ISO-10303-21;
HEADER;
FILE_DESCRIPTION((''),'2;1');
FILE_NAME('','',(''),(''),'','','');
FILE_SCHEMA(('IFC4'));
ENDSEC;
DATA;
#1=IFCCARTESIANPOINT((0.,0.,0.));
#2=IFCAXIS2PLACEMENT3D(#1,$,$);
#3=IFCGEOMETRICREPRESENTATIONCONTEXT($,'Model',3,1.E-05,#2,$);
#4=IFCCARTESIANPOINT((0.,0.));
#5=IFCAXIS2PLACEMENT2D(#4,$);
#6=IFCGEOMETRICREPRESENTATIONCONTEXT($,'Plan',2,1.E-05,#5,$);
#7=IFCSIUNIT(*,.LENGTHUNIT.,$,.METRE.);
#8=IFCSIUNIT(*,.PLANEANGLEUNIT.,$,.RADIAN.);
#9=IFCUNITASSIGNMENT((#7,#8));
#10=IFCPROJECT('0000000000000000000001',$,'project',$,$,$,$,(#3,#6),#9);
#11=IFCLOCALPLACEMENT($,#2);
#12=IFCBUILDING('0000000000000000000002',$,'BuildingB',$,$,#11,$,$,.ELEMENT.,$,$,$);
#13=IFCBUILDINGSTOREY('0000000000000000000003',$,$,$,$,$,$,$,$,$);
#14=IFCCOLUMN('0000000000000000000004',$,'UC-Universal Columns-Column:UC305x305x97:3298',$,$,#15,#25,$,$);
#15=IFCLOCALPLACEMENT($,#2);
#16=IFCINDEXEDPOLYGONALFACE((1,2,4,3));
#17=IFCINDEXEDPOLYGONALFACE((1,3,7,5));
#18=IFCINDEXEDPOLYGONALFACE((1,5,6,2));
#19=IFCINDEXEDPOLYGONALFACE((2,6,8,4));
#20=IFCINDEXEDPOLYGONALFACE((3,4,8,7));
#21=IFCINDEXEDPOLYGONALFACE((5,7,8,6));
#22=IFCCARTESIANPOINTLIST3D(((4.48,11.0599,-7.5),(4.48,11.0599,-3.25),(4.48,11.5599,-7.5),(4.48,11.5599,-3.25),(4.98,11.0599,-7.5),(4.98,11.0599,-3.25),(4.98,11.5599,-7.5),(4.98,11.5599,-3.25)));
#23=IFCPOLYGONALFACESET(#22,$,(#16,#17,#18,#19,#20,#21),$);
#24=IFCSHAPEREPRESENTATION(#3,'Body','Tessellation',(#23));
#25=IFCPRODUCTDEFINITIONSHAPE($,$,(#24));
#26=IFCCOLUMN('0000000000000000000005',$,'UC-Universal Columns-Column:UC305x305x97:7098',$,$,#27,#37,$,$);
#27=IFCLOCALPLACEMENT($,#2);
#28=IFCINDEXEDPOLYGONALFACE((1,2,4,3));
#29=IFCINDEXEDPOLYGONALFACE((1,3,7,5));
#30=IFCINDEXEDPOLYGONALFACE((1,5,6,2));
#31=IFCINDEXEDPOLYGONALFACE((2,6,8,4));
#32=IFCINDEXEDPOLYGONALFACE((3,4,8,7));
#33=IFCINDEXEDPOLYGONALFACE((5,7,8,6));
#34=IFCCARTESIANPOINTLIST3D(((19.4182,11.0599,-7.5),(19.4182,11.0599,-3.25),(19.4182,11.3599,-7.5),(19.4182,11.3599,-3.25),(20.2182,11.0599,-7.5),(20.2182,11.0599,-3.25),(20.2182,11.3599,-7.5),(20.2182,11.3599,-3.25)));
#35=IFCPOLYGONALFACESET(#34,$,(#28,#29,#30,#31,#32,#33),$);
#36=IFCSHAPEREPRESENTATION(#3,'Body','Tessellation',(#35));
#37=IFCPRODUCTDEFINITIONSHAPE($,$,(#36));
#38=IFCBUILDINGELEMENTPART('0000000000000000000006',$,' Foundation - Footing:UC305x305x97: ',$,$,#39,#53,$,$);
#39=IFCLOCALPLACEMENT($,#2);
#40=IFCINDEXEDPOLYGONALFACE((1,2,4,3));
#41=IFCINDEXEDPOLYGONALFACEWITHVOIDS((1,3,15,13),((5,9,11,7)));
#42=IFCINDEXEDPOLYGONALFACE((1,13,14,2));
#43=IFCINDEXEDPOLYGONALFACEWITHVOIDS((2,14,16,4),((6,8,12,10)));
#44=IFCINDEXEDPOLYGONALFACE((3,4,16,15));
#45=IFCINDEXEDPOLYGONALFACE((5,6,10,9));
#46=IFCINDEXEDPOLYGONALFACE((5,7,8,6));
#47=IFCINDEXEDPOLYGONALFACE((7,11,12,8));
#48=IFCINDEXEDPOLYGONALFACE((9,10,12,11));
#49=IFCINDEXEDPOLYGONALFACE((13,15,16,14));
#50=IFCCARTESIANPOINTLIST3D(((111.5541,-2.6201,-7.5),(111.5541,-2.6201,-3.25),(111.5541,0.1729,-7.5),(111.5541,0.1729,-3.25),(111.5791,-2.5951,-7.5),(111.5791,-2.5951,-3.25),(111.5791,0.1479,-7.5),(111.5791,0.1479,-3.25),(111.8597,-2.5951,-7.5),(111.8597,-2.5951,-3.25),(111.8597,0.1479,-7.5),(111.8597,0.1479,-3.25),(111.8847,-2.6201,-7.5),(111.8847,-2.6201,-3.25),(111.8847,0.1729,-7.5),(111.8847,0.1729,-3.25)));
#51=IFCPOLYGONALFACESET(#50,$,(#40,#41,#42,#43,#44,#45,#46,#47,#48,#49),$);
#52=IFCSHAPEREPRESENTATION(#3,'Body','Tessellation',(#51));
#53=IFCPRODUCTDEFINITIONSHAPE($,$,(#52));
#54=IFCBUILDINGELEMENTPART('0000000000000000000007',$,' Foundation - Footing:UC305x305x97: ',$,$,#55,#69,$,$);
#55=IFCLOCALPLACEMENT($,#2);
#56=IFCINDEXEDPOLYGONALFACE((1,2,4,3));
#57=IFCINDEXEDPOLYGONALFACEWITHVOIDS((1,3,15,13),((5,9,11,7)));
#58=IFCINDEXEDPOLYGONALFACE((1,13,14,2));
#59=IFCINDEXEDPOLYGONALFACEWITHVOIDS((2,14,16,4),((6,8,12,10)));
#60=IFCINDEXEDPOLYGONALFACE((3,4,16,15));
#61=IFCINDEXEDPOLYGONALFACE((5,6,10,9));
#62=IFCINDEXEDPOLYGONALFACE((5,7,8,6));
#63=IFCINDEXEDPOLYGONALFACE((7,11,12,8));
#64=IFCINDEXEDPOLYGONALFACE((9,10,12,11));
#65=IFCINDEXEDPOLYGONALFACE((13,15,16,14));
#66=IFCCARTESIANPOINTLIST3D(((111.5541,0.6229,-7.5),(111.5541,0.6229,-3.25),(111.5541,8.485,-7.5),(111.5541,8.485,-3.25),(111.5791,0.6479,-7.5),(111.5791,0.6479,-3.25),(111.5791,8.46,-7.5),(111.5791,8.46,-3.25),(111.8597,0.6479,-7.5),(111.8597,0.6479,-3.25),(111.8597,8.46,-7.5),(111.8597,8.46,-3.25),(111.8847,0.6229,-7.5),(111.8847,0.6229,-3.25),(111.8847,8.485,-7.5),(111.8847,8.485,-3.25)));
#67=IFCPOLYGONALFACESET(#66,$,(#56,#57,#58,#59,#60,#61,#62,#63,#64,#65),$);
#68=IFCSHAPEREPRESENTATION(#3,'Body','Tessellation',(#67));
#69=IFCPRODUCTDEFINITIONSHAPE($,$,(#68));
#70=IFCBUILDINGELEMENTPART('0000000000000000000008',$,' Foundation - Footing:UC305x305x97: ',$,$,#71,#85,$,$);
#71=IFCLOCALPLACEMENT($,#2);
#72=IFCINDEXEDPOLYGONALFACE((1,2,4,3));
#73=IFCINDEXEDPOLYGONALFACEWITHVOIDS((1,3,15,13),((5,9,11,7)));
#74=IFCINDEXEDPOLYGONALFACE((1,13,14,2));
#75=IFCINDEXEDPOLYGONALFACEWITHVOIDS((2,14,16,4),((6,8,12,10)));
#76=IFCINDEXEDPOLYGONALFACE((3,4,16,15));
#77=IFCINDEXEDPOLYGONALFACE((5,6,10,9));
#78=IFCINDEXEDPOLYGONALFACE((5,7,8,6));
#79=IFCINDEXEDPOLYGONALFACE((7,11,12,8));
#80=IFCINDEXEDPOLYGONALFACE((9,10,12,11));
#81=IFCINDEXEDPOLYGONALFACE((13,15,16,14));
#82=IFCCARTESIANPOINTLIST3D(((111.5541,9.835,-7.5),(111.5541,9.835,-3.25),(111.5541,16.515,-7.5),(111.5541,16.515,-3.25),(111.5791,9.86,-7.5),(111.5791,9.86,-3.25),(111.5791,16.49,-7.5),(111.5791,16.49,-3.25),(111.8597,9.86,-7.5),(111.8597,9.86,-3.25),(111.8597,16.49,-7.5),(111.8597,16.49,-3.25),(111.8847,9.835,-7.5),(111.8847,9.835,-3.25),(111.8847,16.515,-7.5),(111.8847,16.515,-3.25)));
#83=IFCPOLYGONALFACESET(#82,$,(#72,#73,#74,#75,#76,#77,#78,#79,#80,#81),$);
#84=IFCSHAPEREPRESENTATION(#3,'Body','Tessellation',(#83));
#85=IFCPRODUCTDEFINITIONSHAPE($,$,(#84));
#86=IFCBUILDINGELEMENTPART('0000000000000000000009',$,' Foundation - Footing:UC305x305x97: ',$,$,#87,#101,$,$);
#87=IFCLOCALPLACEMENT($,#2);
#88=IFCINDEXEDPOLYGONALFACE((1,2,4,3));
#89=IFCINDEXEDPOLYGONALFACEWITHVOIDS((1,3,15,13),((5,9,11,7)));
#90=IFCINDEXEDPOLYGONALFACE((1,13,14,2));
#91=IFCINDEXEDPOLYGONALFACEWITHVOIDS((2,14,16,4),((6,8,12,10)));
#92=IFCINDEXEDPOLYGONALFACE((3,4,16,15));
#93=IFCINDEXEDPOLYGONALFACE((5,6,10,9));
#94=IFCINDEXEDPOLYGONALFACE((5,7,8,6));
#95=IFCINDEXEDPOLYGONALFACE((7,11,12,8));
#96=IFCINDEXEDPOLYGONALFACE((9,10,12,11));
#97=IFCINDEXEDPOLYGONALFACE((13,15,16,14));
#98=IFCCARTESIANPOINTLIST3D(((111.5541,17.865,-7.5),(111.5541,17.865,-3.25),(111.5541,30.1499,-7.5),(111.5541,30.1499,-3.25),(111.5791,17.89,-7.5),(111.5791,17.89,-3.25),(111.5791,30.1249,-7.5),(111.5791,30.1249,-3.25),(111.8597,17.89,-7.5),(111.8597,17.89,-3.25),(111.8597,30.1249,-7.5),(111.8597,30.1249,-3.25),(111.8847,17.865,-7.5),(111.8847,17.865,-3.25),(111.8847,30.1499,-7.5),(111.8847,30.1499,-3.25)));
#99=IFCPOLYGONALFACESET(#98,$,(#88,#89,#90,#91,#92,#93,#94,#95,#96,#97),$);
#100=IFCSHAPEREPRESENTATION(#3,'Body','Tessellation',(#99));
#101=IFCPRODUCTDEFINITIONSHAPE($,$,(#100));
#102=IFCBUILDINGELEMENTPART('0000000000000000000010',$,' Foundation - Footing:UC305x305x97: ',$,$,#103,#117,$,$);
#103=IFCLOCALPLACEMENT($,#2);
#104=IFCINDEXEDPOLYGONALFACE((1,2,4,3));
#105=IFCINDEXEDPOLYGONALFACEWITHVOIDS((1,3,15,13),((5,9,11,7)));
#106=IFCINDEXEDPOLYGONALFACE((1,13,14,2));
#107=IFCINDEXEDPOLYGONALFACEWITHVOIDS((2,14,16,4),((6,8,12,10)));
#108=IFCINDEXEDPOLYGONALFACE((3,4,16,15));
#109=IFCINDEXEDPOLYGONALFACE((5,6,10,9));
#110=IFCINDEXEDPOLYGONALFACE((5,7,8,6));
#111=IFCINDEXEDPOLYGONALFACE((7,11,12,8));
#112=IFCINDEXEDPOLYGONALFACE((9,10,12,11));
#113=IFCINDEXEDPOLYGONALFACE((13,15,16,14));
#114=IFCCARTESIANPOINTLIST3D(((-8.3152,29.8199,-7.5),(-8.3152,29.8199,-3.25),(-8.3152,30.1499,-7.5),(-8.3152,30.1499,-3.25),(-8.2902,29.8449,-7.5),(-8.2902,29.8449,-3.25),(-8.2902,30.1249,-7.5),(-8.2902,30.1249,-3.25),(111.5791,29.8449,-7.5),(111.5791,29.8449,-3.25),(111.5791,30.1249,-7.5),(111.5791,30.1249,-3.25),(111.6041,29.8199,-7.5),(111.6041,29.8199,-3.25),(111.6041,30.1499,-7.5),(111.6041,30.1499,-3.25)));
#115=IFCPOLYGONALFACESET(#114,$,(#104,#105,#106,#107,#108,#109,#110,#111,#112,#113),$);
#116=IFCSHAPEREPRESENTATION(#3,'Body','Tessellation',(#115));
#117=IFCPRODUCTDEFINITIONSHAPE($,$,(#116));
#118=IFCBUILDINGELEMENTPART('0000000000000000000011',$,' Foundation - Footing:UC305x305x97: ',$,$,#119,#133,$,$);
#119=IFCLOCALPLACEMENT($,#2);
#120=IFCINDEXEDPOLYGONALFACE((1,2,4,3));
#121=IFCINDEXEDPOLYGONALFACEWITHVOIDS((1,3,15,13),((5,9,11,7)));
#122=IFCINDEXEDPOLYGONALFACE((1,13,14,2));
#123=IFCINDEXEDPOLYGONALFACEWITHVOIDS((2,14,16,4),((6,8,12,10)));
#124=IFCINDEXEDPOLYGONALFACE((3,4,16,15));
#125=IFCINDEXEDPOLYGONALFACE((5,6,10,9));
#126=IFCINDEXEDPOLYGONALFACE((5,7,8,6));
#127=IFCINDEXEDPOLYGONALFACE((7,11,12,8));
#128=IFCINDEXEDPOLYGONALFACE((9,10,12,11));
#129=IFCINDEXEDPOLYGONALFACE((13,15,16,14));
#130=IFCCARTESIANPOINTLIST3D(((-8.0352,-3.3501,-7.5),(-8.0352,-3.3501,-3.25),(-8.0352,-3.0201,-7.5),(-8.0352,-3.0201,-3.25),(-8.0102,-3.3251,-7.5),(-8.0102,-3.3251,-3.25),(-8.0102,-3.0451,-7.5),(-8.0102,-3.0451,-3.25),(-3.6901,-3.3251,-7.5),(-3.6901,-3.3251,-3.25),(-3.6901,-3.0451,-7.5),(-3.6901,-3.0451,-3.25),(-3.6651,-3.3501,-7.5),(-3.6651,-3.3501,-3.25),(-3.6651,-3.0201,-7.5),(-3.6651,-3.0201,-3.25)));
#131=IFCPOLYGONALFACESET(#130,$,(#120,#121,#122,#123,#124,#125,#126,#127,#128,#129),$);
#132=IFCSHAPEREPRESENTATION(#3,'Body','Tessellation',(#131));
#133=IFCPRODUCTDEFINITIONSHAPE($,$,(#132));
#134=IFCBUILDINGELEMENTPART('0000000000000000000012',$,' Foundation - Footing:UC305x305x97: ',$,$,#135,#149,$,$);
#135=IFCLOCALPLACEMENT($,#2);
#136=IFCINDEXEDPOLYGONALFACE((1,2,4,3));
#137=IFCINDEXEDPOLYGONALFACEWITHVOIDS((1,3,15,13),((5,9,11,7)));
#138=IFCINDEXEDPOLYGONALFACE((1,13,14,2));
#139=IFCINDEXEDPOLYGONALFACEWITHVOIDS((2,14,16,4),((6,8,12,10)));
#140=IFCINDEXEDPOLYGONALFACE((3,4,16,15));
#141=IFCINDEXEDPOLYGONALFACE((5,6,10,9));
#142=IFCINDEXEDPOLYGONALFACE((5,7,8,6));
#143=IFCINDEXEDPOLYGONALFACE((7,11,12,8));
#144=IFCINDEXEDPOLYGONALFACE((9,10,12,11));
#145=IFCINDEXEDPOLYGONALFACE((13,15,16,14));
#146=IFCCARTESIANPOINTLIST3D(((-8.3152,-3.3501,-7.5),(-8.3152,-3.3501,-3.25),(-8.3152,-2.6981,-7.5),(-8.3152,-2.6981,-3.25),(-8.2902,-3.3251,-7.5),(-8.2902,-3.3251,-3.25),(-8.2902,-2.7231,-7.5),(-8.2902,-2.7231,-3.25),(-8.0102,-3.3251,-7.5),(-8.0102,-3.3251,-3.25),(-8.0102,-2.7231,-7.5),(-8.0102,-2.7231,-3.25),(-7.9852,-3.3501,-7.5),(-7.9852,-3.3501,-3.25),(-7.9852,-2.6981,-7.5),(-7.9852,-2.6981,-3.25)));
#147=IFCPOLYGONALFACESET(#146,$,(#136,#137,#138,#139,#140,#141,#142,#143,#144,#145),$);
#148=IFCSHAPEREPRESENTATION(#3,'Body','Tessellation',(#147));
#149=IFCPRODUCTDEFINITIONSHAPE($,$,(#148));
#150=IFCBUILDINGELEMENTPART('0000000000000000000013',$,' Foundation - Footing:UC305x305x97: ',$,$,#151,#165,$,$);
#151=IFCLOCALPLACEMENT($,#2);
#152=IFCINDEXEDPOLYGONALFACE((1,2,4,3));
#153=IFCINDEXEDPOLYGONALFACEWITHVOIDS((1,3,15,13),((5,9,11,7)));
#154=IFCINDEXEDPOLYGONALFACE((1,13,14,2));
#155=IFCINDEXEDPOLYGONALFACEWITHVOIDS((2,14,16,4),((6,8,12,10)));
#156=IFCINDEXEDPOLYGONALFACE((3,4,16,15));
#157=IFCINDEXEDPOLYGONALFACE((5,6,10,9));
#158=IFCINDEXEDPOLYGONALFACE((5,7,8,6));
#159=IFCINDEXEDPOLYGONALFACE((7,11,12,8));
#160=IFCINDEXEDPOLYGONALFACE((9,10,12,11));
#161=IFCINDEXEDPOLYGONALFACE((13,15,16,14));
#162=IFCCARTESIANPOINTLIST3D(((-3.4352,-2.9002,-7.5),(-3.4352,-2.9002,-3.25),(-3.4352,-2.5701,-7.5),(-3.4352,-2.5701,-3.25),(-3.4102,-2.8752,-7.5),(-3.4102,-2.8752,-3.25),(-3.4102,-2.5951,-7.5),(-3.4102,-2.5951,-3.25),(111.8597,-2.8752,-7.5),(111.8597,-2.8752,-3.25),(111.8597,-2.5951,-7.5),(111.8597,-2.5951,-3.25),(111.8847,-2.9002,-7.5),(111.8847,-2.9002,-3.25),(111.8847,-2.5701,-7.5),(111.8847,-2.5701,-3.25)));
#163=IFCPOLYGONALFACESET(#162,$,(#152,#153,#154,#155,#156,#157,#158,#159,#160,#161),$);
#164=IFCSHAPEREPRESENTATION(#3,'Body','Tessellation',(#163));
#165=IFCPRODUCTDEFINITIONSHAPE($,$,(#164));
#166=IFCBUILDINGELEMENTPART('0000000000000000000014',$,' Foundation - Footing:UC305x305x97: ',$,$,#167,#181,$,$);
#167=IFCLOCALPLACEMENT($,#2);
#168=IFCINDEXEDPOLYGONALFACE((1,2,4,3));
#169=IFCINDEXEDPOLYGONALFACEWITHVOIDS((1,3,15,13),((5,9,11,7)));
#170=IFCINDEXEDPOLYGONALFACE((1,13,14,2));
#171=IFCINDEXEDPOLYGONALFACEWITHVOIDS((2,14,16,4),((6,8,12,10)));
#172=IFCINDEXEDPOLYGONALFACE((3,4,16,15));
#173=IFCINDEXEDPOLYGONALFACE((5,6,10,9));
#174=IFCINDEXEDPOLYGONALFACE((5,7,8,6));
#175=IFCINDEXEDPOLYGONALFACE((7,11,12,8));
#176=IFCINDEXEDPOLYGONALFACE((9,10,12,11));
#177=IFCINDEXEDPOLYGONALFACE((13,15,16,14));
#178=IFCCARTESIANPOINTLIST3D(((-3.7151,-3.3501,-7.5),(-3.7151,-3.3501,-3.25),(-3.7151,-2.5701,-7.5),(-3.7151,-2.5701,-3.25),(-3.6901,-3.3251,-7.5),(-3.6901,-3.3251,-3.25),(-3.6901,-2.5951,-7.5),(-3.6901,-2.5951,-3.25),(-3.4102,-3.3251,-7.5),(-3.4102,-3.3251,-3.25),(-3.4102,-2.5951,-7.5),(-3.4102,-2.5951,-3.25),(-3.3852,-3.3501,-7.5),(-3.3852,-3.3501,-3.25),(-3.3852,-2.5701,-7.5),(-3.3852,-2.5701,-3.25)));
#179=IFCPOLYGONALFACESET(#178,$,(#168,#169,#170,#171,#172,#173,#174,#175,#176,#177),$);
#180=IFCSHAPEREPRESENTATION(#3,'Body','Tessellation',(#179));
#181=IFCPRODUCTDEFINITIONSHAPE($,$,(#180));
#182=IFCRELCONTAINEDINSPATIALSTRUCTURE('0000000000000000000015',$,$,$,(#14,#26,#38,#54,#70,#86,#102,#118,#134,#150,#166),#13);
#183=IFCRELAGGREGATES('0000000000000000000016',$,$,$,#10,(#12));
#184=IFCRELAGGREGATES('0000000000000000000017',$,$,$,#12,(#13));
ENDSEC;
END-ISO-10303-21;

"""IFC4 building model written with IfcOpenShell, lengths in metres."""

from ifc_helpers import new_model, si_unit, origin, origin_2d, place, context, project, spatial, polyline, outline, extrude, element, save


model = new_model("IFC4")

# Units and contexts
model_context = context("Model", 3, precision=1e-05, world=origin())
plan_context = context("Plan", 2, precision=1e-05, world=origin_2d())
ifc_project = project(units=[si_unit("LENGTHUNIT", "METRE"), si_unit("PLANEANGLEUNIT", "RADIAN")], contexts=[model_context, plan_context])

# Building, storey
building_placement = place(None, origin())
building = spatial("IfcBuilding", under=ifc_project, at=building_placement, Name="BuildingB", CompositionType="ELEMENT")
storey = spatial("IfcBuildingStorey", under=building)

# Columns
element("IfcColumn", 1, inside=storey, Name="UC-Universal Columns-Column:UC305x305x97:3298", context=model_context, shape_type="SweptSolid", body=[
    extrude(outline(polyline([(4.98, 11.0599, -7.5), (4.48, 11.0599, -7.5), (4.48, 11.5599, -7.5), (4.98, 11.5599, -7.5), (4.98, 11.0599, -7.5)])), None, (0.0, 0.0, 1.0), 4.25),
])
element("IfcColumn", 2, inside=storey, Name="UC-Universal Columns-Column:UC305x305x97:7098", context=model_context, shape_type="SweptSolid", body=[
    extrude(outline(polyline([(19.4182, 11.0599, -7.5), (20.2182, 11.0599, -7.5), (20.2182, 11.3599, -7.5), (19.4182, 11.3599, -7.5), (19.4182, 11.0599, -7.5)])), None, (0.0, 0.0, 1.0), 4.25),
])

# Building element parts, openings
building_element_part_1 = element("IfcBuildingElementPart", 3, inside=storey, Name=" Foundation - Footing:UC305x305x97: ", context=model_context, shape_type="SweptSolid", body=[
    extrude(outline(polyline([(111.5541, -2.6201, -7.5), (111.5541, 0.1729, -7.5), (111.8847, 0.1729, -7.5), (111.8847, -2.6201, -7.5), (111.5541, -2.6201, -7.5)])), None, (0.0, 0.0, 1.0), 4.25),
])
element("IfcOpeningElement", 4, inside=storey, cuts=building_element_part_1, context=model_context, shape_type="SweptSolid", body=[
    extrude(outline(polyline([(111.5791, -2.5951, -7.5), (111.5791, 0.1479, -7.5), (111.8597, 0.1479, -7.5), (111.8597, -2.5951, -7.5), (111.5791, -2.5951, -7.5)])), None, (0.0, 0.0, 1.0), 4.25),
])
building_element_part_2 = element("IfcBuildingElementPart", 5, inside=storey, Name=" Foundation - Footing:UC305x305x97: ", context=model_context, shape_type="SweptSolid", body=[
    extrude(outline(polyline([(111.8847, 0.6229, -7.5), (111.5541, 0.6229, -7.5), (111.5541, 8.485, -7.5), (111.8847, 8.485, -7.5), (111.8847, 0.6229, -7.5)])), None, (0.0, 0.0, 1.0), 4.25),
])
element("IfcOpeningElement", 6, inside=storey, cuts=building_element_part_2, context=model_context, shape_type="SweptSolid", body=[
    extrude(outline(polyline([(111.8597, 0.6479, -7.5), (111.5791, 0.6479, -7.5), (111.5791, 8.46, -7.5), (111.8597, 8.46, -7.5), (111.8597, 0.6479, -7.5)])), None, (0.0, 0.0, 1.0), 4.25),
])
building_element_part_3 = element("IfcBuildingElementPart", 7, inside=storey, Name=" Foundation - Footing:UC305x305x97: ", context=model_context, shape_type="SweptSolid", body=[
    extrude(outline(polyline([(111.8847, 9.835, -7.5), (111.5541, 9.835, -7.5), (111.5541, 16.515, -7.5), (111.8847, 16.515, -7.5), (111.8847, 9.835, -7.5)])), None, (0.0, 0.0, 1.0), 4.25),
])
element("IfcOpeningElement", 8, inside=storey, cuts=building_element_part_3, context=model_context, shape_type="SweptSolid", body=[
    extrude(outline(polyline([(111.8597, 9.86, -7.5), (111.5791, 9.86, -7.5), (111.5791, 16.49, -7.5), (111.8597, 16.49, -7.5), (111.8597, 9.86, -7.5)])), None, (0.0, 0.0, 1.0), 4.25),
])
building_element_part_4 = element("IfcBuildingElementPart", 9, inside=storey, Name=" Foundation - Footing:UC305x305x97: ", context=model_context, shape_type="SweptSolid", body=[
    extrude(outline(polyline([(111.8847, 30.1499, -7.5), (111.8847, 17.865, -7.5), (111.5541, 17.865, -7.5), (111.5541, 30.1499, -7.5), (111.8847, 30.1499, -7.5)])), None, (0.0, 0.0, 1.0), 4.25),
])
element("IfcOpeningElement", 10, inside=storey, cuts=building_element_part_4, context=model_context, shape_type="SweptSolid", body=[
    extrude(outline(polyline([(111.8597, 30.1249, -7.5), (111.8597, 17.89, -7.5), (111.5791, 17.89, -7.5), (111.5791, 30.1249, -7.5), (111.8597, 30.1249, -7.5)])), None, (0.0, 0.0, 1.0), 4.25),
])
building_element_part_5 = element("IfcBuildingElementPart", 11, inside=storey, Name=" Foundation - Footing:UC305x305x97: ", context=model_context, shape_type="SweptSolid", body=[
    extrude(outline(polyline([(-8.3152, 30.1499, -7.5), (111.6041, 30.1499, -7.5), (111.6041, 29.8199, -7.5), (-8.3152, 29.8199, -7.5), (-8.3152, 30.1499, -7.5)])), None, (0.0, 0.0, 1.0), 4.25),
])
element("IfcOpeningElement", 12, inside=storey, cuts=building_element_part_5, context=model_context, shape_type="SweptSolid", body=[
    extrude(outline(polyline([(-8.2902, 30.1249, -7.5), (111.5791, 30.1249, -7.5), (111.5791, 29.8449, -7.5), (-8.2902, 29.8449, -7.5), (-8.2902, 30.1249, -7.5)])), None, (0.0, 0.0, 1.0), 4.25),
])
building_element_part_6 = element("IfcBuildingElementPart", 13, inside=storey, Name=" Foundation - Footing:UC305x305x97: ", context=model_context, shape_type="SweptSolid", body=[
    extrude(outline(polyline([(-3.6651, -3.3501, -7.5), (-8.0352, -3.3501, -7.5), (-8.0352, -3.0201, -7.5), (-3.6651, -3.0201, -7.5), (-3.6651, -3.3501, -7.5)])), None, (0.0, 0.0, 1.0), 4.25),
])
element("IfcOpeningElement", 14, inside=storey, cuts=building_element_part_6, context=model_context, shape_type="SweptSolid", body=[
    extrude(outline(polyline([(-3.6901, -3.3251, -7.5), (-8.0102, -3.3251, -7.5), (-8.0102, -3.0451, -7.5), (-3.6901, -3.0451, -7.5), (-3.6901, -3.3251, -7.5)])), None, (0.0, 0.0, 1.0), 4.25),
])
building_element_part_7 = element("IfcBuildingElementPart", 15, inside=storey, Name=" Foundation - Footing:UC305x305x97: ", context=model_context, shape_type="SweptSolid", body=[
    extrude(outline(polyline([(-7.9852, -3.3501, -7.5), (-8.3152, -3.3501, -7.5), (-8.3152, -2.6981, -7.5), (-7.9852, -2.6981, -7.5), (-7.9852, -3.3501, -7.5)])), None, (0.0, 0.0, 1.0), 4.25),
])
element("IfcOpeningElement", 16, inside=storey, cuts=building_element_part_7, context=model_context, shape_type="SweptSolid", body=[
    extrude(outline(polyline([(-8.0102, -3.3251, -7.5), (-8.2902, -3.3251, -7.5), (-8.2902, -2.7231, -7.5), (-8.0102, -2.7231, -7.5), (-8.0102, -3.3251, -7.5)])), None, (0.0, 0.0, 1.0), 4.25),
])
building_element_part_8 = element("IfcBuildingElementPart", 17, inside=storey, Name=" Foundation - Footing:UC305x305x97: ", context=model_context, shape_type="SweptSolid", body=[
    extrude(outline(polyline([(-3.4352, -2.5701, -7.5), (111.8847, -2.5701, -7.5), (111.8847, -2.9002, -7.5), (-3.4352, -2.9002, -7.5), (-3.4352, -2.5701, -7.5)])), None, (0.0, 0.0, 1.0), 4.25),
])
element("IfcOpeningElement", 18, inside=storey, cuts=building_element_part_8, context=model_context, shape_type="SweptSolid", body=[
    extrude(outline(polyline([(-3.4102, -2.5951, -7.5), (111.8597, -2.5951, -7.5), (111.8597, -2.8752, -7.5), (-3.4102, -2.8752, -7.5), (-3.4102, -2.5951, -7.5)])), None, (0.0, 0.0, 1.0), 4.25),
])
building_element_part_9 = element("IfcBuildingElementPart", 19, inside=storey, Name=" Foundation - Footing:UC305x305x97: ", context=model_context, shape_type="SweptSolid", body=[
    extrude(outline(polyline([(-3.3852, -2.5701, -7.5), (-3.3852, -3.3501, -7.5), (-3.7151, -3.3501, -7.5), (-3.7151, -2.5701, -7.5), (-3.3852, -2.5701, -7.5)])), None, (0.0, 0.0, 1.0), 4.25),
])
element("IfcOpeningElement", 20, inside=storey, cuts=building_element_part_9, context=model_context, shape_type="SweptSolid", body=[
    extrude(outline(polyline([(-3.4102, -2.5951, -7.5), (-3.4102, -3.3251, -7.5), (-3.6901, -3.3251, -7.5), (-3.6901, -2.5951, -7.5), (-3.4102, -2.5951, -7.5)])), None, (0.0, 0.0, 1.0), 4.25),
])

save(model, "model.ifc")
